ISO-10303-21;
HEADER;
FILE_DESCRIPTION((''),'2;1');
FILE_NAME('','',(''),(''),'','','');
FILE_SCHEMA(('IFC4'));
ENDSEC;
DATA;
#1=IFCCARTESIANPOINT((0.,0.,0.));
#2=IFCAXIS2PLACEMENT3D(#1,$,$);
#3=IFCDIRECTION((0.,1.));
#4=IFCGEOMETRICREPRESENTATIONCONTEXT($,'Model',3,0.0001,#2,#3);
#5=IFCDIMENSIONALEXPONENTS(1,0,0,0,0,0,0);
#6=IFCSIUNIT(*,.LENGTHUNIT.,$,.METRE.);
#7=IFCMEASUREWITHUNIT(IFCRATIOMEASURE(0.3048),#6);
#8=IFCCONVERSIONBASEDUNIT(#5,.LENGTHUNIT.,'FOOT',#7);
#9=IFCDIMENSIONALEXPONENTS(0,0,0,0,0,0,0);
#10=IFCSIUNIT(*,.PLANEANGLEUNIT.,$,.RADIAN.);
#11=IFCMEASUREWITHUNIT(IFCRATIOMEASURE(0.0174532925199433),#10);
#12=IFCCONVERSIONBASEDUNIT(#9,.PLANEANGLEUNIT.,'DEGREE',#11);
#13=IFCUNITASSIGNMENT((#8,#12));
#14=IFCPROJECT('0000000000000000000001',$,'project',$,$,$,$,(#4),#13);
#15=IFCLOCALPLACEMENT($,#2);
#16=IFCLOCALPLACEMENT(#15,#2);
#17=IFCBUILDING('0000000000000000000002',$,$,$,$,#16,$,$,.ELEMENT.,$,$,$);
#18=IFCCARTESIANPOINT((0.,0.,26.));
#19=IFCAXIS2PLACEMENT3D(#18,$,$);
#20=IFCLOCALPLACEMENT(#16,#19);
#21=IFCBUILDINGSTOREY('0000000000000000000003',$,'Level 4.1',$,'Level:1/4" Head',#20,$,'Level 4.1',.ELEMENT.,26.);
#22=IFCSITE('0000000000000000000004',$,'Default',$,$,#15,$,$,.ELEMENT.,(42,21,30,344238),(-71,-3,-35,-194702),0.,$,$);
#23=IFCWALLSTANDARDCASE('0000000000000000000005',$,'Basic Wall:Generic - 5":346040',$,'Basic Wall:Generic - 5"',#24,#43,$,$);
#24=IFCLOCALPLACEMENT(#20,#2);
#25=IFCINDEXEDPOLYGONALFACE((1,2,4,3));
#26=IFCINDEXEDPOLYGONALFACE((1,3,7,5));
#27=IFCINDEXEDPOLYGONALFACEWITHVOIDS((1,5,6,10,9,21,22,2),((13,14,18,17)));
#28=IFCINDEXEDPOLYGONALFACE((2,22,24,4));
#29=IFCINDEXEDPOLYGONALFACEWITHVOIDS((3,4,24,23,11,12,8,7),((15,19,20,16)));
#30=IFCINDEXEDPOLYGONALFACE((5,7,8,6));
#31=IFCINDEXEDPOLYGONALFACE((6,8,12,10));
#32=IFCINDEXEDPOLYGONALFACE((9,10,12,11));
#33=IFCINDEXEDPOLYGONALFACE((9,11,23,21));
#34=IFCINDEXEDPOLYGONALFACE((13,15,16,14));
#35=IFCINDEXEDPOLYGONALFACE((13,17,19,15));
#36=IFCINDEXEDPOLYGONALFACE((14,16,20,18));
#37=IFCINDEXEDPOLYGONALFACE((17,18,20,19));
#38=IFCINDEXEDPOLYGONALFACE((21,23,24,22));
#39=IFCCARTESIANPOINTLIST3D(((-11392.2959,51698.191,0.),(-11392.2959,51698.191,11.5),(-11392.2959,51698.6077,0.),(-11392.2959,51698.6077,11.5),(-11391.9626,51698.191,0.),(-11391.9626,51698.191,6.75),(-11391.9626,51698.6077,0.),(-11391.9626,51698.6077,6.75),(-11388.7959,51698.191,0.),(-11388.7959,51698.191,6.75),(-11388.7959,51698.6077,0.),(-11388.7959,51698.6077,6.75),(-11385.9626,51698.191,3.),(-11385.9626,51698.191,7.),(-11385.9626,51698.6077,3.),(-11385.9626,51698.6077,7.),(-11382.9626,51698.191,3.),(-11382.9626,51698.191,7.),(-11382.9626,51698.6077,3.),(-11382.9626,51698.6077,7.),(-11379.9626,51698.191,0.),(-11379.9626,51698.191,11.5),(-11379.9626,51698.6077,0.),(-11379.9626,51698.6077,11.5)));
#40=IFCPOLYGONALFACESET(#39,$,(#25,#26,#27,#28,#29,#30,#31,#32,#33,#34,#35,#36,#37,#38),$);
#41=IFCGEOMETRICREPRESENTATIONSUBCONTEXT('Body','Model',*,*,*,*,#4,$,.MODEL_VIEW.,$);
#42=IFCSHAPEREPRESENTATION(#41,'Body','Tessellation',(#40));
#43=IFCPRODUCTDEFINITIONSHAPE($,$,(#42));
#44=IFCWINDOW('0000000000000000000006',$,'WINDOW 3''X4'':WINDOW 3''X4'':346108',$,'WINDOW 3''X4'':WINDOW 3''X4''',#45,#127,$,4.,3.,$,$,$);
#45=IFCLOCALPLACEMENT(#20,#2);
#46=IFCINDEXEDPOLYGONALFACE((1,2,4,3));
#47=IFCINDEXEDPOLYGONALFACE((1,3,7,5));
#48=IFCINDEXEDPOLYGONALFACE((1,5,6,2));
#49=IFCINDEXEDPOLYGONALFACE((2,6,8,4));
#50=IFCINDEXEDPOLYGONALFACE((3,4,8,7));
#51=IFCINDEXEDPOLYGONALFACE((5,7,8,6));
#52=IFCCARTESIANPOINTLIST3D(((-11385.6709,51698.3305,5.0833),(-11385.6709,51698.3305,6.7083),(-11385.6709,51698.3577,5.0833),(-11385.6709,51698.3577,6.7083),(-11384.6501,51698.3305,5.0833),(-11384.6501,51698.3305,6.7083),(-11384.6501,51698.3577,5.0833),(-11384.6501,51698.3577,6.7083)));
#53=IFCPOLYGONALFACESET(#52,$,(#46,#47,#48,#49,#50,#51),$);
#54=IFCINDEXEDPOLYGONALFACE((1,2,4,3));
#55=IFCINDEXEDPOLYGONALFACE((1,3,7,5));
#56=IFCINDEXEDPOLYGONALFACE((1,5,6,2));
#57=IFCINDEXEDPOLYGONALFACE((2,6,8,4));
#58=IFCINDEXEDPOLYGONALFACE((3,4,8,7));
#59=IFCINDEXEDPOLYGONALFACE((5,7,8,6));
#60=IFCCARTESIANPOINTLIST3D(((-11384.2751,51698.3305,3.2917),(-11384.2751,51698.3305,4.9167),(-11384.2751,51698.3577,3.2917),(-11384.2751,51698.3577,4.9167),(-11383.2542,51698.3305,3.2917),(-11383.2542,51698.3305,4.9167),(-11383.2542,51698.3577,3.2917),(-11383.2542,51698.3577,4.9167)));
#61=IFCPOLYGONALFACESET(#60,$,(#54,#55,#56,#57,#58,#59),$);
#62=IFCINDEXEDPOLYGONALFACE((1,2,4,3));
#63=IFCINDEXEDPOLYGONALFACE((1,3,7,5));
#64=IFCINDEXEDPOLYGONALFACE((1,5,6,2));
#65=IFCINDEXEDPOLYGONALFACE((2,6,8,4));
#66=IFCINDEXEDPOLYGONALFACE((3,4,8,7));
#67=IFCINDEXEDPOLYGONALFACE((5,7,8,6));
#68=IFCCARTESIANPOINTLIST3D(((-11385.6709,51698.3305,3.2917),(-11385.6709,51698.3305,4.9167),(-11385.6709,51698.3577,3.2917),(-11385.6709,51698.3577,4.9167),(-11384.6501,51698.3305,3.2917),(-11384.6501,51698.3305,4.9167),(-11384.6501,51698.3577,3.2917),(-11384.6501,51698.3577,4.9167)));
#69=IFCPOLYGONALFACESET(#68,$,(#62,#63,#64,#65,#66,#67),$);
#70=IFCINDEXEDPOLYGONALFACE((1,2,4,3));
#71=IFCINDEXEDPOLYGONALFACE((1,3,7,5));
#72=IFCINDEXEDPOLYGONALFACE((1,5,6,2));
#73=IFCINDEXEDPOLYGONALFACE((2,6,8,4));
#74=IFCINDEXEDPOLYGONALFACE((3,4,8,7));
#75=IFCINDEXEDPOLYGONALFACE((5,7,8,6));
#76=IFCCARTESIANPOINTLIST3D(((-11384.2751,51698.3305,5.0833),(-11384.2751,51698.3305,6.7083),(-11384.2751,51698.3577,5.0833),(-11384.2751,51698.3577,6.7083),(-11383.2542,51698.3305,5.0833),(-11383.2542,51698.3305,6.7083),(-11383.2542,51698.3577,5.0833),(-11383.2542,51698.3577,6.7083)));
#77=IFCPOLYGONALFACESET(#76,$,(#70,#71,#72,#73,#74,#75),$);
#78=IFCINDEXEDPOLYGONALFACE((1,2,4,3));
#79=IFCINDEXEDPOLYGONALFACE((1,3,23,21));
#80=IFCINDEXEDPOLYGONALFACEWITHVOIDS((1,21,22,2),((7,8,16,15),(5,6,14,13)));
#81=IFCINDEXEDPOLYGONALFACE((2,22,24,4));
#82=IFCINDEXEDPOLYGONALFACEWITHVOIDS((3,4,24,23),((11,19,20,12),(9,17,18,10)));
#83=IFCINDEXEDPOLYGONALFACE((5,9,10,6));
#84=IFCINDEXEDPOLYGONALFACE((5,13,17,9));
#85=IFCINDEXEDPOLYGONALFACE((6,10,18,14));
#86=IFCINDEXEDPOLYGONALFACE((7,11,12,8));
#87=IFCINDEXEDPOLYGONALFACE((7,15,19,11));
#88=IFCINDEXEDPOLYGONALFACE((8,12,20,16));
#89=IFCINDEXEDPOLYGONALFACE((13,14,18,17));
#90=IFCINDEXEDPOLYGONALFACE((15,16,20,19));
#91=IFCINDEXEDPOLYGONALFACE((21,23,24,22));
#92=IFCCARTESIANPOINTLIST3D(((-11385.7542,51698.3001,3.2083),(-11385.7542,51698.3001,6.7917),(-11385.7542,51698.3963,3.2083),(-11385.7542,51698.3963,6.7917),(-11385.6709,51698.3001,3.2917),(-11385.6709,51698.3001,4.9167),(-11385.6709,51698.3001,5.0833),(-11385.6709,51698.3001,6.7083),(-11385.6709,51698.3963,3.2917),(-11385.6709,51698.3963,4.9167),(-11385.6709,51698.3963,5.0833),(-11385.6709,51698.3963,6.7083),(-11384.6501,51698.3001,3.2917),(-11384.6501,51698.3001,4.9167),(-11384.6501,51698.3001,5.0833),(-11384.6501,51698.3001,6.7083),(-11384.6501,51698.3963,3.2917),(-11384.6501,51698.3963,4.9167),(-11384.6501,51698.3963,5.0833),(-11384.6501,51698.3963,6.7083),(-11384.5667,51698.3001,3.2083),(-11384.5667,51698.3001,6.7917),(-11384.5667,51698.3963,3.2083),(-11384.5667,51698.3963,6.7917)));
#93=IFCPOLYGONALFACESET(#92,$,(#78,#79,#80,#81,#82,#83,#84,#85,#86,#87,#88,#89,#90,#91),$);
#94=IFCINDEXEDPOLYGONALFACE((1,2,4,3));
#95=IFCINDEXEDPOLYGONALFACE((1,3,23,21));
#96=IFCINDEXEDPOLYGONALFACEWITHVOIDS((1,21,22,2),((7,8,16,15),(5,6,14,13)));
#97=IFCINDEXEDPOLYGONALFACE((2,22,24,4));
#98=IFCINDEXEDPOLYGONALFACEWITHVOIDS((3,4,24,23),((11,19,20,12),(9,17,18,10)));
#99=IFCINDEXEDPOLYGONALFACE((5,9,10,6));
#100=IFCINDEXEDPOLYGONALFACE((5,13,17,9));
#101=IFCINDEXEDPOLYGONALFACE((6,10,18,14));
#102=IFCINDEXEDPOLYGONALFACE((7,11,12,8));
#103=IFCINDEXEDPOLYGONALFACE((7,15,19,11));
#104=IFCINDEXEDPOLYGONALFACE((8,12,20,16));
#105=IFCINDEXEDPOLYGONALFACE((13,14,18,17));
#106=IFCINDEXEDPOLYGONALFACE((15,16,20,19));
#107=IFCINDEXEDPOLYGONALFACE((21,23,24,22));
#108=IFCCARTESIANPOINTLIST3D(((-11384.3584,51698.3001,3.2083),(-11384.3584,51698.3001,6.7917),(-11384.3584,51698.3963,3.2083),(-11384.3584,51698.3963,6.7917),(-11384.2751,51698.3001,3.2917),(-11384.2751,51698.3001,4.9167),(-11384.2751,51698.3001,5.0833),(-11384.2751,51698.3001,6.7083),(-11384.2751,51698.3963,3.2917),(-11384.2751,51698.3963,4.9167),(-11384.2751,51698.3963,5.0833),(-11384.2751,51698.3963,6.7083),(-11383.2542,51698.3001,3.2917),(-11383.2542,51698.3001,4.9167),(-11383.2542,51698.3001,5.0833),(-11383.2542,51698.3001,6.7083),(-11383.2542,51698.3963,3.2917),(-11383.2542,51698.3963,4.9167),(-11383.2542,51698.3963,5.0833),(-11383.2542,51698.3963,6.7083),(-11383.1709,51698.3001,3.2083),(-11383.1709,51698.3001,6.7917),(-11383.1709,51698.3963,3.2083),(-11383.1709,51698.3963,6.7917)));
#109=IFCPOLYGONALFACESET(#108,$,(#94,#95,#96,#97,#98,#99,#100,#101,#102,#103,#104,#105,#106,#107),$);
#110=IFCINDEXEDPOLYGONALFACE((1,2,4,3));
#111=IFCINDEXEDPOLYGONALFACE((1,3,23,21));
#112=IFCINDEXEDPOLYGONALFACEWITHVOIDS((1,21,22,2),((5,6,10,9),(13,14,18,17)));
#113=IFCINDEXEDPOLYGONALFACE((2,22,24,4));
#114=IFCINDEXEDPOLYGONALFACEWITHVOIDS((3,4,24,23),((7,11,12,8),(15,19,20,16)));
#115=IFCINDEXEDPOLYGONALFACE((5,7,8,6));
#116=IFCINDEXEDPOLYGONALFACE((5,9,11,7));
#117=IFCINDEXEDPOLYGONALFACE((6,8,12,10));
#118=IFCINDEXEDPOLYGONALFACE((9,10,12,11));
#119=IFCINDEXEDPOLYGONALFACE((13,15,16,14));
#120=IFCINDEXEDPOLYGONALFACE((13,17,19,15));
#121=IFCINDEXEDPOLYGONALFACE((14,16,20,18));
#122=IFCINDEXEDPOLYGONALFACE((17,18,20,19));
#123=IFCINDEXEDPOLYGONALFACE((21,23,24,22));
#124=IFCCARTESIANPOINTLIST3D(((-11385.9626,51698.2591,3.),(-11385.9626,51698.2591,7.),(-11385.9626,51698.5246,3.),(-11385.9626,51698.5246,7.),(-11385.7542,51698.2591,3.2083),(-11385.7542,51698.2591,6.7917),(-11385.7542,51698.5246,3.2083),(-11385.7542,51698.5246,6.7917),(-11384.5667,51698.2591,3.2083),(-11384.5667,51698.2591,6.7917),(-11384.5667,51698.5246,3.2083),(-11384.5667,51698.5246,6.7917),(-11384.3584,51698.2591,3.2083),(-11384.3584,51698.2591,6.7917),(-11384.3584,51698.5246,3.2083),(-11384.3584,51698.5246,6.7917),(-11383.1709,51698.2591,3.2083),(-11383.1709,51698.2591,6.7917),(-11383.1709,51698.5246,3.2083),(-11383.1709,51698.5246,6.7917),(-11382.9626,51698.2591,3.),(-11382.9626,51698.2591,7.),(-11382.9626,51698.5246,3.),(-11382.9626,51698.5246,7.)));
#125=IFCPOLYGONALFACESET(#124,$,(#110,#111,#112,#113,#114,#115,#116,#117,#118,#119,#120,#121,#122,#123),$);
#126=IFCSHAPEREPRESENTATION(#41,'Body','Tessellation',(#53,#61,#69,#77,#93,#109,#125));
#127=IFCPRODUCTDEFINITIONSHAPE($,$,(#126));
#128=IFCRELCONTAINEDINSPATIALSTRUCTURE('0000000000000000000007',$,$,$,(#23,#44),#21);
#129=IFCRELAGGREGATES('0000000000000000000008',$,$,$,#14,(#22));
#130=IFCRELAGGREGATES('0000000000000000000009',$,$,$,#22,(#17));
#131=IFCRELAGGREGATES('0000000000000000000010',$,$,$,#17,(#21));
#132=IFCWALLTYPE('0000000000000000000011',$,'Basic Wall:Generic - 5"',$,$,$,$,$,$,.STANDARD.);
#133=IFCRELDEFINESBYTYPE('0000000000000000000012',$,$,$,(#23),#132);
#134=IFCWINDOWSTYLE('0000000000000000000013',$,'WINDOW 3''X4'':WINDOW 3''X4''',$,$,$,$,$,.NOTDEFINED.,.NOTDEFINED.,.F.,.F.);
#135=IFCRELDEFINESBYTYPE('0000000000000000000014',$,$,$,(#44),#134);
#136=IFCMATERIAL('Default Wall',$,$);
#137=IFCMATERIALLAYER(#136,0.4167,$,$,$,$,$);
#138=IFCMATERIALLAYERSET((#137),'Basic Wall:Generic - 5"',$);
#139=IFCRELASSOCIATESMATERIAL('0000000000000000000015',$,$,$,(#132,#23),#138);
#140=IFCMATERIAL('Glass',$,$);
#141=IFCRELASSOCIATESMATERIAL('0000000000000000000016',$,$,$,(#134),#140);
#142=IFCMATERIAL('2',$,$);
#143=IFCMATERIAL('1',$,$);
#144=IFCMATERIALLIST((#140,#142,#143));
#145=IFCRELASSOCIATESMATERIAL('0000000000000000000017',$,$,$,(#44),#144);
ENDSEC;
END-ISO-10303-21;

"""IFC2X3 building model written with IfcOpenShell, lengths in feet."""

from ifc_helpers import new_model, entity, si_unit, converted_unit, direction, frame, frame_2d, origin, origin_2d_with_axis, place, context, subcontext, project, spatial, polyline, rectangle, outline, extrude, source, transform, mapped, material, material_list, layer, layer_set, layer_usage, type_object, type_shapes, element, fill, save


model = new_model("IFC2X3")

# Units and contexts
model_context = context("Model", 3, precision=0.0001, world=origin(), true_north=direction((0.0, 1.0)))
body_context = subcontext(model_context, "Body", "Model", "MODEL_VIEW")
ifc_project = project(units=[converted_unit("LENGTHUNIT", "FOOT", entity("IfcRatioMeasure", 0.3048), si_unit("LENGTHUNIT", "METRE"), dimensions=[1, 0, 0, 0, 0, 0, 0]), converted_unit("PLANEANGLEUNIT", "DEGREE", entity("IfcRatioMeasure", 0.0174532925199433), si_unit("PLANEANGLEUNIT", "RADIAN"), dimensions=[0, 0, 0, 0, 0, 0, 0])], contexts=[model_context])

# Site, building, storey
site_placement = place(None, origin())
site = spatial("IfcSite", under=ifc_project, at=site_placement, Name="Default", CompositionType="ELEMENT", RefLatitude=(42, 21, 30, 344238), RefLongitude=(-71, -3, -35, -194702), RefElevation=0.0)
building_placement = place(site_placement, origin())
building = spatial("IfcBuilding", under=site, at=building_placement, CompositionType="ELEMENT")
storey_placement = place(building_placement, frame((0.0, 0.0, 26.0)))
storey = spatial("IfcBuildingStorey", under=building, at=storey_placement, Name="Level 4.1", ObjectType="Level:1/4\" Head", LongName="Level 4.1", CompositionType="ELEMENT", Elevation=26.0)

# Shared definitions
ifc_material_1 = material(Name="Default Wall")
ifc_material_2 = material(Name="Glass")
ifc_material_3 = material(Name="2")
ifc_material_4 = material(Name="1")
ifc_layer_1 = layer(ifc_material_1, 0.4167)
ifc_layer_set_1 = layer_set([ifc_layer_1], Name="Basic Wall:Generic - 5\"")
wall_type_1 = type_object("IfcWallType", Name="Basic Wall:Generic - 5\"", PredefinedType="STANDARD", material=ifc_layer_set_1)

# Wall, openings, window
window_style_1 = type_object("IfcWindowStyle", Name="WINDOW 3'X4':WINDOW 3'X4'", ConstructionType="NOTDEFINED", OperationType="NOTDEFINED", ParameterTakesPrecedence=False, Sizeable=False, material=ifc_material_2)
shared_shape_1 = source(origin(), body_context, "Body", "SweptSolid", [
    extrude(rectangle(XDim=0.0272, YDim=1.0208, at=origin_2d_with_axis()), frame((2.1979, 0.2636, 2.0833), z_axis=(0.0, 0.0, 1.0), x_axis=(0.0, 1.0, 0.0)), (0.0, 0.0, 1.0), 1.625),
    extrude(rectangle(XDim=0.0272, YDim=1.0208, at=origin_2d_with_axis()), frame((0.8021, 0.2636, 0.2917), z_axis=(0.0, 0.0, 1.0), x_axis=(0.0, 1.0, 0.0)), (0.0, 0.0, 1.0), 1.625),
    extrude(rectangle(XDim=0.0272, YDim=1.0208, at=origin_2d_with_axis()), frame((2.1979, 0.2636, 0.2917), z_axis=(0.0, 0.0, 1.0), x_axis=(0.0, 1.0, 0.0)), (0.0, 0.0, 1.0), 1.625),
    extrude(rectangle(XDim=0.0272, YDim=1.0208, at=origin_2d_with_axis()), frame((0.8021, 0.2636, 2.0833), z_axis=(0.0, 0.0, 1.0), x_axis=(0.0, 1.0, 0.0)), (0.0, 0.0, 1.0), 1.625),
    extrude(outline(polyline([(-0.5938, -1.7917), (0.5938, -1.7917), (0.5938, 1.7917), (-0.5938, 1.7917), (-0.5938, -1.7917)]), holes=[polyline([(-0.5104, -0.0833), (0.5104, -0.0833), (0.5104, -1.7083), (-0.5104, -1.7083), (-0.5104, -0.0833)]), polyline([(-0.5104, 1.7083), (0.5104, 1.7083), (0.5104, 0.0833), (-0.5104, 0.0833), (-0.5104, 1.7083)])]), frame((2.1979, 0.2114, 2.0), z_axis=(0.0, 1.0, 0.0), x_axis=(-1.0, 0.0, 0.0)), (0.0, 0.0, 1.0), 0.0962),
    extrude(outline(polyline([(-1.7917, -0.5937), (1.7917, -0.5937), (1.7917, 0.5937), (-1.7917, 0.5937), (-1.7917, -0.5937)]), holes=[polyline([(0.0833, -0.5104), (0.0833, 0.5104), (1.7083, 0.5104), (1.7083, -0.5104), (0.0833, -0.5104)]), polyline([(-1.7083, -0.5104), (-1.7083, 0.5104), (-0.0833, 0.5104), (-0.0833, -0.5104), (-1.7083, -0.5104)])]), frame((0.8021, 0.2114, 2.0), z_axis=(0.0, 1.0, 0.0), x_axis=(0.0, 0.0, -1.0)), (0.0, 0.0, 1.0), 0.0962),
    extrude(outline(polyline([(-1.5, -2.0), (1.5, -2.0), (1.5, 2.0), (-1.5, 2.0), (-1.5, -2.0)]), holes=[polyline([(-0.1042, 1.7917), (-0.1042, -1.7917), (-1.2917, -1.7917), (-1.2917, 1.7917), (-0.1042, 1.7917)]), polyline([(0.1042, -1.7917), (0.1042, 1.7917), (1.2917, 1.7917), (1.2917, -1.7917), (0.1042, -1.7917)])]), frame((1.5, 0.0831, 2.0), z_axis=(0.0, 1.0, 0.0), x_axis=(1.0, 0.0, 0.0)), (0.0, 0.0, 1.0), 0.2655),
])
type_shapes(window_style_1, [shared_shape_1])
ifc_layer_usage_1 = layer_usage(ifc_layer_set_1, "AXIS2", "NEGATIVE", 0.2083)
wall_1_placement = place(storey_placement, frame((-11379.9626, 51698.3993, 0.0), z_axis=(0.0, 0.0, 1.0), x_axis=(-1.0, 0.0, 0.0)))
wall_1 = element("IfcWallStandardCase", 1, at=wall_1_placement, inside=storey, type_object=wall_type_1, material=ifc_layer_usage_1, Name="Basic Wall:Generic - 5\":346040", ObjectType="Basic Wall:Generic - 5\"", context=body_context, shape_type="SweptSolid", body=[
    extrude(rectangle(XDim=12.3333, YDim=0.4167, at=frame_2d((6.1667, 0.0), x_axis=(-1.0, 0.0))), origin(), (0.0, 0.0, 1.0), 11.5),
])
opening_1_placement = place(wall_1_placement, frame((12.0, 0.2083, 0.0)))
element("IfcOpeningElement", 2, at=opening_1_placement, cuts=wall_1, ObjectType="Opening", context=body_context, shape_type="SweptSolid", body=[
    extrude(rectangle(XDim=6.75, YDim=3.1667, at=frame_2d((3.375, 1.5833), x_axis=(1.0, 0.0))), frame((0.0, 0.0, 0.0), z_axis=(0.0, -1.0, 0.0), x_axis=(0.0, 0.0, 1.0)), (0.0, 0.0, 1.0), 0.4167),
])
opening_2_placement = place(wall_1_placement, frame((3.0, -0.2083, 3.0)))
opening_2 = element("IfcOpeningElement", 3, at=opening_2_placement, cuts=wall_1, ObjectType="Opening", context=body_context, shape_type="SweptSolid", body=[
    extrude(rectangle(XDim=4.0, YDim=3.0, at=frame_2d((2.0, 1.5), x_axis=(-1.0, 0.0))), frame((0.0, 0.0, 0.0), z_axis=(0.0, 1.0, 0.0), x_axis=(0.0, 0.0, 1.0)), (0.0, 0.0, 1.0), 0.4167),
])
ifc_material_list_1 = material_list([ifc_material_2, ifc_material_3, ifc_material_4])
window_1_placement = place(opening_2_placement, origin())
window_1 = element("IfcWindow", 4, at=window_1_placement, inside=storey, type_object=window_style_1, material=ifc_material_list_1, Name="WINDOW 3'X4':WINDOW 3'X4':346108", ObjectType="WINDOW 3'X4':WINDOW 3'X4'", OverallHeight=4.0, OverallWidth=3.0, context=body_context, shape_type="MappedRepresentation", body=[
    mapped(shared_shape_1, transform((0.0, 0.0, 0.0), scale=1.0)),
])
fill(opening_2, window_1)

save(model, "model.ifc")
